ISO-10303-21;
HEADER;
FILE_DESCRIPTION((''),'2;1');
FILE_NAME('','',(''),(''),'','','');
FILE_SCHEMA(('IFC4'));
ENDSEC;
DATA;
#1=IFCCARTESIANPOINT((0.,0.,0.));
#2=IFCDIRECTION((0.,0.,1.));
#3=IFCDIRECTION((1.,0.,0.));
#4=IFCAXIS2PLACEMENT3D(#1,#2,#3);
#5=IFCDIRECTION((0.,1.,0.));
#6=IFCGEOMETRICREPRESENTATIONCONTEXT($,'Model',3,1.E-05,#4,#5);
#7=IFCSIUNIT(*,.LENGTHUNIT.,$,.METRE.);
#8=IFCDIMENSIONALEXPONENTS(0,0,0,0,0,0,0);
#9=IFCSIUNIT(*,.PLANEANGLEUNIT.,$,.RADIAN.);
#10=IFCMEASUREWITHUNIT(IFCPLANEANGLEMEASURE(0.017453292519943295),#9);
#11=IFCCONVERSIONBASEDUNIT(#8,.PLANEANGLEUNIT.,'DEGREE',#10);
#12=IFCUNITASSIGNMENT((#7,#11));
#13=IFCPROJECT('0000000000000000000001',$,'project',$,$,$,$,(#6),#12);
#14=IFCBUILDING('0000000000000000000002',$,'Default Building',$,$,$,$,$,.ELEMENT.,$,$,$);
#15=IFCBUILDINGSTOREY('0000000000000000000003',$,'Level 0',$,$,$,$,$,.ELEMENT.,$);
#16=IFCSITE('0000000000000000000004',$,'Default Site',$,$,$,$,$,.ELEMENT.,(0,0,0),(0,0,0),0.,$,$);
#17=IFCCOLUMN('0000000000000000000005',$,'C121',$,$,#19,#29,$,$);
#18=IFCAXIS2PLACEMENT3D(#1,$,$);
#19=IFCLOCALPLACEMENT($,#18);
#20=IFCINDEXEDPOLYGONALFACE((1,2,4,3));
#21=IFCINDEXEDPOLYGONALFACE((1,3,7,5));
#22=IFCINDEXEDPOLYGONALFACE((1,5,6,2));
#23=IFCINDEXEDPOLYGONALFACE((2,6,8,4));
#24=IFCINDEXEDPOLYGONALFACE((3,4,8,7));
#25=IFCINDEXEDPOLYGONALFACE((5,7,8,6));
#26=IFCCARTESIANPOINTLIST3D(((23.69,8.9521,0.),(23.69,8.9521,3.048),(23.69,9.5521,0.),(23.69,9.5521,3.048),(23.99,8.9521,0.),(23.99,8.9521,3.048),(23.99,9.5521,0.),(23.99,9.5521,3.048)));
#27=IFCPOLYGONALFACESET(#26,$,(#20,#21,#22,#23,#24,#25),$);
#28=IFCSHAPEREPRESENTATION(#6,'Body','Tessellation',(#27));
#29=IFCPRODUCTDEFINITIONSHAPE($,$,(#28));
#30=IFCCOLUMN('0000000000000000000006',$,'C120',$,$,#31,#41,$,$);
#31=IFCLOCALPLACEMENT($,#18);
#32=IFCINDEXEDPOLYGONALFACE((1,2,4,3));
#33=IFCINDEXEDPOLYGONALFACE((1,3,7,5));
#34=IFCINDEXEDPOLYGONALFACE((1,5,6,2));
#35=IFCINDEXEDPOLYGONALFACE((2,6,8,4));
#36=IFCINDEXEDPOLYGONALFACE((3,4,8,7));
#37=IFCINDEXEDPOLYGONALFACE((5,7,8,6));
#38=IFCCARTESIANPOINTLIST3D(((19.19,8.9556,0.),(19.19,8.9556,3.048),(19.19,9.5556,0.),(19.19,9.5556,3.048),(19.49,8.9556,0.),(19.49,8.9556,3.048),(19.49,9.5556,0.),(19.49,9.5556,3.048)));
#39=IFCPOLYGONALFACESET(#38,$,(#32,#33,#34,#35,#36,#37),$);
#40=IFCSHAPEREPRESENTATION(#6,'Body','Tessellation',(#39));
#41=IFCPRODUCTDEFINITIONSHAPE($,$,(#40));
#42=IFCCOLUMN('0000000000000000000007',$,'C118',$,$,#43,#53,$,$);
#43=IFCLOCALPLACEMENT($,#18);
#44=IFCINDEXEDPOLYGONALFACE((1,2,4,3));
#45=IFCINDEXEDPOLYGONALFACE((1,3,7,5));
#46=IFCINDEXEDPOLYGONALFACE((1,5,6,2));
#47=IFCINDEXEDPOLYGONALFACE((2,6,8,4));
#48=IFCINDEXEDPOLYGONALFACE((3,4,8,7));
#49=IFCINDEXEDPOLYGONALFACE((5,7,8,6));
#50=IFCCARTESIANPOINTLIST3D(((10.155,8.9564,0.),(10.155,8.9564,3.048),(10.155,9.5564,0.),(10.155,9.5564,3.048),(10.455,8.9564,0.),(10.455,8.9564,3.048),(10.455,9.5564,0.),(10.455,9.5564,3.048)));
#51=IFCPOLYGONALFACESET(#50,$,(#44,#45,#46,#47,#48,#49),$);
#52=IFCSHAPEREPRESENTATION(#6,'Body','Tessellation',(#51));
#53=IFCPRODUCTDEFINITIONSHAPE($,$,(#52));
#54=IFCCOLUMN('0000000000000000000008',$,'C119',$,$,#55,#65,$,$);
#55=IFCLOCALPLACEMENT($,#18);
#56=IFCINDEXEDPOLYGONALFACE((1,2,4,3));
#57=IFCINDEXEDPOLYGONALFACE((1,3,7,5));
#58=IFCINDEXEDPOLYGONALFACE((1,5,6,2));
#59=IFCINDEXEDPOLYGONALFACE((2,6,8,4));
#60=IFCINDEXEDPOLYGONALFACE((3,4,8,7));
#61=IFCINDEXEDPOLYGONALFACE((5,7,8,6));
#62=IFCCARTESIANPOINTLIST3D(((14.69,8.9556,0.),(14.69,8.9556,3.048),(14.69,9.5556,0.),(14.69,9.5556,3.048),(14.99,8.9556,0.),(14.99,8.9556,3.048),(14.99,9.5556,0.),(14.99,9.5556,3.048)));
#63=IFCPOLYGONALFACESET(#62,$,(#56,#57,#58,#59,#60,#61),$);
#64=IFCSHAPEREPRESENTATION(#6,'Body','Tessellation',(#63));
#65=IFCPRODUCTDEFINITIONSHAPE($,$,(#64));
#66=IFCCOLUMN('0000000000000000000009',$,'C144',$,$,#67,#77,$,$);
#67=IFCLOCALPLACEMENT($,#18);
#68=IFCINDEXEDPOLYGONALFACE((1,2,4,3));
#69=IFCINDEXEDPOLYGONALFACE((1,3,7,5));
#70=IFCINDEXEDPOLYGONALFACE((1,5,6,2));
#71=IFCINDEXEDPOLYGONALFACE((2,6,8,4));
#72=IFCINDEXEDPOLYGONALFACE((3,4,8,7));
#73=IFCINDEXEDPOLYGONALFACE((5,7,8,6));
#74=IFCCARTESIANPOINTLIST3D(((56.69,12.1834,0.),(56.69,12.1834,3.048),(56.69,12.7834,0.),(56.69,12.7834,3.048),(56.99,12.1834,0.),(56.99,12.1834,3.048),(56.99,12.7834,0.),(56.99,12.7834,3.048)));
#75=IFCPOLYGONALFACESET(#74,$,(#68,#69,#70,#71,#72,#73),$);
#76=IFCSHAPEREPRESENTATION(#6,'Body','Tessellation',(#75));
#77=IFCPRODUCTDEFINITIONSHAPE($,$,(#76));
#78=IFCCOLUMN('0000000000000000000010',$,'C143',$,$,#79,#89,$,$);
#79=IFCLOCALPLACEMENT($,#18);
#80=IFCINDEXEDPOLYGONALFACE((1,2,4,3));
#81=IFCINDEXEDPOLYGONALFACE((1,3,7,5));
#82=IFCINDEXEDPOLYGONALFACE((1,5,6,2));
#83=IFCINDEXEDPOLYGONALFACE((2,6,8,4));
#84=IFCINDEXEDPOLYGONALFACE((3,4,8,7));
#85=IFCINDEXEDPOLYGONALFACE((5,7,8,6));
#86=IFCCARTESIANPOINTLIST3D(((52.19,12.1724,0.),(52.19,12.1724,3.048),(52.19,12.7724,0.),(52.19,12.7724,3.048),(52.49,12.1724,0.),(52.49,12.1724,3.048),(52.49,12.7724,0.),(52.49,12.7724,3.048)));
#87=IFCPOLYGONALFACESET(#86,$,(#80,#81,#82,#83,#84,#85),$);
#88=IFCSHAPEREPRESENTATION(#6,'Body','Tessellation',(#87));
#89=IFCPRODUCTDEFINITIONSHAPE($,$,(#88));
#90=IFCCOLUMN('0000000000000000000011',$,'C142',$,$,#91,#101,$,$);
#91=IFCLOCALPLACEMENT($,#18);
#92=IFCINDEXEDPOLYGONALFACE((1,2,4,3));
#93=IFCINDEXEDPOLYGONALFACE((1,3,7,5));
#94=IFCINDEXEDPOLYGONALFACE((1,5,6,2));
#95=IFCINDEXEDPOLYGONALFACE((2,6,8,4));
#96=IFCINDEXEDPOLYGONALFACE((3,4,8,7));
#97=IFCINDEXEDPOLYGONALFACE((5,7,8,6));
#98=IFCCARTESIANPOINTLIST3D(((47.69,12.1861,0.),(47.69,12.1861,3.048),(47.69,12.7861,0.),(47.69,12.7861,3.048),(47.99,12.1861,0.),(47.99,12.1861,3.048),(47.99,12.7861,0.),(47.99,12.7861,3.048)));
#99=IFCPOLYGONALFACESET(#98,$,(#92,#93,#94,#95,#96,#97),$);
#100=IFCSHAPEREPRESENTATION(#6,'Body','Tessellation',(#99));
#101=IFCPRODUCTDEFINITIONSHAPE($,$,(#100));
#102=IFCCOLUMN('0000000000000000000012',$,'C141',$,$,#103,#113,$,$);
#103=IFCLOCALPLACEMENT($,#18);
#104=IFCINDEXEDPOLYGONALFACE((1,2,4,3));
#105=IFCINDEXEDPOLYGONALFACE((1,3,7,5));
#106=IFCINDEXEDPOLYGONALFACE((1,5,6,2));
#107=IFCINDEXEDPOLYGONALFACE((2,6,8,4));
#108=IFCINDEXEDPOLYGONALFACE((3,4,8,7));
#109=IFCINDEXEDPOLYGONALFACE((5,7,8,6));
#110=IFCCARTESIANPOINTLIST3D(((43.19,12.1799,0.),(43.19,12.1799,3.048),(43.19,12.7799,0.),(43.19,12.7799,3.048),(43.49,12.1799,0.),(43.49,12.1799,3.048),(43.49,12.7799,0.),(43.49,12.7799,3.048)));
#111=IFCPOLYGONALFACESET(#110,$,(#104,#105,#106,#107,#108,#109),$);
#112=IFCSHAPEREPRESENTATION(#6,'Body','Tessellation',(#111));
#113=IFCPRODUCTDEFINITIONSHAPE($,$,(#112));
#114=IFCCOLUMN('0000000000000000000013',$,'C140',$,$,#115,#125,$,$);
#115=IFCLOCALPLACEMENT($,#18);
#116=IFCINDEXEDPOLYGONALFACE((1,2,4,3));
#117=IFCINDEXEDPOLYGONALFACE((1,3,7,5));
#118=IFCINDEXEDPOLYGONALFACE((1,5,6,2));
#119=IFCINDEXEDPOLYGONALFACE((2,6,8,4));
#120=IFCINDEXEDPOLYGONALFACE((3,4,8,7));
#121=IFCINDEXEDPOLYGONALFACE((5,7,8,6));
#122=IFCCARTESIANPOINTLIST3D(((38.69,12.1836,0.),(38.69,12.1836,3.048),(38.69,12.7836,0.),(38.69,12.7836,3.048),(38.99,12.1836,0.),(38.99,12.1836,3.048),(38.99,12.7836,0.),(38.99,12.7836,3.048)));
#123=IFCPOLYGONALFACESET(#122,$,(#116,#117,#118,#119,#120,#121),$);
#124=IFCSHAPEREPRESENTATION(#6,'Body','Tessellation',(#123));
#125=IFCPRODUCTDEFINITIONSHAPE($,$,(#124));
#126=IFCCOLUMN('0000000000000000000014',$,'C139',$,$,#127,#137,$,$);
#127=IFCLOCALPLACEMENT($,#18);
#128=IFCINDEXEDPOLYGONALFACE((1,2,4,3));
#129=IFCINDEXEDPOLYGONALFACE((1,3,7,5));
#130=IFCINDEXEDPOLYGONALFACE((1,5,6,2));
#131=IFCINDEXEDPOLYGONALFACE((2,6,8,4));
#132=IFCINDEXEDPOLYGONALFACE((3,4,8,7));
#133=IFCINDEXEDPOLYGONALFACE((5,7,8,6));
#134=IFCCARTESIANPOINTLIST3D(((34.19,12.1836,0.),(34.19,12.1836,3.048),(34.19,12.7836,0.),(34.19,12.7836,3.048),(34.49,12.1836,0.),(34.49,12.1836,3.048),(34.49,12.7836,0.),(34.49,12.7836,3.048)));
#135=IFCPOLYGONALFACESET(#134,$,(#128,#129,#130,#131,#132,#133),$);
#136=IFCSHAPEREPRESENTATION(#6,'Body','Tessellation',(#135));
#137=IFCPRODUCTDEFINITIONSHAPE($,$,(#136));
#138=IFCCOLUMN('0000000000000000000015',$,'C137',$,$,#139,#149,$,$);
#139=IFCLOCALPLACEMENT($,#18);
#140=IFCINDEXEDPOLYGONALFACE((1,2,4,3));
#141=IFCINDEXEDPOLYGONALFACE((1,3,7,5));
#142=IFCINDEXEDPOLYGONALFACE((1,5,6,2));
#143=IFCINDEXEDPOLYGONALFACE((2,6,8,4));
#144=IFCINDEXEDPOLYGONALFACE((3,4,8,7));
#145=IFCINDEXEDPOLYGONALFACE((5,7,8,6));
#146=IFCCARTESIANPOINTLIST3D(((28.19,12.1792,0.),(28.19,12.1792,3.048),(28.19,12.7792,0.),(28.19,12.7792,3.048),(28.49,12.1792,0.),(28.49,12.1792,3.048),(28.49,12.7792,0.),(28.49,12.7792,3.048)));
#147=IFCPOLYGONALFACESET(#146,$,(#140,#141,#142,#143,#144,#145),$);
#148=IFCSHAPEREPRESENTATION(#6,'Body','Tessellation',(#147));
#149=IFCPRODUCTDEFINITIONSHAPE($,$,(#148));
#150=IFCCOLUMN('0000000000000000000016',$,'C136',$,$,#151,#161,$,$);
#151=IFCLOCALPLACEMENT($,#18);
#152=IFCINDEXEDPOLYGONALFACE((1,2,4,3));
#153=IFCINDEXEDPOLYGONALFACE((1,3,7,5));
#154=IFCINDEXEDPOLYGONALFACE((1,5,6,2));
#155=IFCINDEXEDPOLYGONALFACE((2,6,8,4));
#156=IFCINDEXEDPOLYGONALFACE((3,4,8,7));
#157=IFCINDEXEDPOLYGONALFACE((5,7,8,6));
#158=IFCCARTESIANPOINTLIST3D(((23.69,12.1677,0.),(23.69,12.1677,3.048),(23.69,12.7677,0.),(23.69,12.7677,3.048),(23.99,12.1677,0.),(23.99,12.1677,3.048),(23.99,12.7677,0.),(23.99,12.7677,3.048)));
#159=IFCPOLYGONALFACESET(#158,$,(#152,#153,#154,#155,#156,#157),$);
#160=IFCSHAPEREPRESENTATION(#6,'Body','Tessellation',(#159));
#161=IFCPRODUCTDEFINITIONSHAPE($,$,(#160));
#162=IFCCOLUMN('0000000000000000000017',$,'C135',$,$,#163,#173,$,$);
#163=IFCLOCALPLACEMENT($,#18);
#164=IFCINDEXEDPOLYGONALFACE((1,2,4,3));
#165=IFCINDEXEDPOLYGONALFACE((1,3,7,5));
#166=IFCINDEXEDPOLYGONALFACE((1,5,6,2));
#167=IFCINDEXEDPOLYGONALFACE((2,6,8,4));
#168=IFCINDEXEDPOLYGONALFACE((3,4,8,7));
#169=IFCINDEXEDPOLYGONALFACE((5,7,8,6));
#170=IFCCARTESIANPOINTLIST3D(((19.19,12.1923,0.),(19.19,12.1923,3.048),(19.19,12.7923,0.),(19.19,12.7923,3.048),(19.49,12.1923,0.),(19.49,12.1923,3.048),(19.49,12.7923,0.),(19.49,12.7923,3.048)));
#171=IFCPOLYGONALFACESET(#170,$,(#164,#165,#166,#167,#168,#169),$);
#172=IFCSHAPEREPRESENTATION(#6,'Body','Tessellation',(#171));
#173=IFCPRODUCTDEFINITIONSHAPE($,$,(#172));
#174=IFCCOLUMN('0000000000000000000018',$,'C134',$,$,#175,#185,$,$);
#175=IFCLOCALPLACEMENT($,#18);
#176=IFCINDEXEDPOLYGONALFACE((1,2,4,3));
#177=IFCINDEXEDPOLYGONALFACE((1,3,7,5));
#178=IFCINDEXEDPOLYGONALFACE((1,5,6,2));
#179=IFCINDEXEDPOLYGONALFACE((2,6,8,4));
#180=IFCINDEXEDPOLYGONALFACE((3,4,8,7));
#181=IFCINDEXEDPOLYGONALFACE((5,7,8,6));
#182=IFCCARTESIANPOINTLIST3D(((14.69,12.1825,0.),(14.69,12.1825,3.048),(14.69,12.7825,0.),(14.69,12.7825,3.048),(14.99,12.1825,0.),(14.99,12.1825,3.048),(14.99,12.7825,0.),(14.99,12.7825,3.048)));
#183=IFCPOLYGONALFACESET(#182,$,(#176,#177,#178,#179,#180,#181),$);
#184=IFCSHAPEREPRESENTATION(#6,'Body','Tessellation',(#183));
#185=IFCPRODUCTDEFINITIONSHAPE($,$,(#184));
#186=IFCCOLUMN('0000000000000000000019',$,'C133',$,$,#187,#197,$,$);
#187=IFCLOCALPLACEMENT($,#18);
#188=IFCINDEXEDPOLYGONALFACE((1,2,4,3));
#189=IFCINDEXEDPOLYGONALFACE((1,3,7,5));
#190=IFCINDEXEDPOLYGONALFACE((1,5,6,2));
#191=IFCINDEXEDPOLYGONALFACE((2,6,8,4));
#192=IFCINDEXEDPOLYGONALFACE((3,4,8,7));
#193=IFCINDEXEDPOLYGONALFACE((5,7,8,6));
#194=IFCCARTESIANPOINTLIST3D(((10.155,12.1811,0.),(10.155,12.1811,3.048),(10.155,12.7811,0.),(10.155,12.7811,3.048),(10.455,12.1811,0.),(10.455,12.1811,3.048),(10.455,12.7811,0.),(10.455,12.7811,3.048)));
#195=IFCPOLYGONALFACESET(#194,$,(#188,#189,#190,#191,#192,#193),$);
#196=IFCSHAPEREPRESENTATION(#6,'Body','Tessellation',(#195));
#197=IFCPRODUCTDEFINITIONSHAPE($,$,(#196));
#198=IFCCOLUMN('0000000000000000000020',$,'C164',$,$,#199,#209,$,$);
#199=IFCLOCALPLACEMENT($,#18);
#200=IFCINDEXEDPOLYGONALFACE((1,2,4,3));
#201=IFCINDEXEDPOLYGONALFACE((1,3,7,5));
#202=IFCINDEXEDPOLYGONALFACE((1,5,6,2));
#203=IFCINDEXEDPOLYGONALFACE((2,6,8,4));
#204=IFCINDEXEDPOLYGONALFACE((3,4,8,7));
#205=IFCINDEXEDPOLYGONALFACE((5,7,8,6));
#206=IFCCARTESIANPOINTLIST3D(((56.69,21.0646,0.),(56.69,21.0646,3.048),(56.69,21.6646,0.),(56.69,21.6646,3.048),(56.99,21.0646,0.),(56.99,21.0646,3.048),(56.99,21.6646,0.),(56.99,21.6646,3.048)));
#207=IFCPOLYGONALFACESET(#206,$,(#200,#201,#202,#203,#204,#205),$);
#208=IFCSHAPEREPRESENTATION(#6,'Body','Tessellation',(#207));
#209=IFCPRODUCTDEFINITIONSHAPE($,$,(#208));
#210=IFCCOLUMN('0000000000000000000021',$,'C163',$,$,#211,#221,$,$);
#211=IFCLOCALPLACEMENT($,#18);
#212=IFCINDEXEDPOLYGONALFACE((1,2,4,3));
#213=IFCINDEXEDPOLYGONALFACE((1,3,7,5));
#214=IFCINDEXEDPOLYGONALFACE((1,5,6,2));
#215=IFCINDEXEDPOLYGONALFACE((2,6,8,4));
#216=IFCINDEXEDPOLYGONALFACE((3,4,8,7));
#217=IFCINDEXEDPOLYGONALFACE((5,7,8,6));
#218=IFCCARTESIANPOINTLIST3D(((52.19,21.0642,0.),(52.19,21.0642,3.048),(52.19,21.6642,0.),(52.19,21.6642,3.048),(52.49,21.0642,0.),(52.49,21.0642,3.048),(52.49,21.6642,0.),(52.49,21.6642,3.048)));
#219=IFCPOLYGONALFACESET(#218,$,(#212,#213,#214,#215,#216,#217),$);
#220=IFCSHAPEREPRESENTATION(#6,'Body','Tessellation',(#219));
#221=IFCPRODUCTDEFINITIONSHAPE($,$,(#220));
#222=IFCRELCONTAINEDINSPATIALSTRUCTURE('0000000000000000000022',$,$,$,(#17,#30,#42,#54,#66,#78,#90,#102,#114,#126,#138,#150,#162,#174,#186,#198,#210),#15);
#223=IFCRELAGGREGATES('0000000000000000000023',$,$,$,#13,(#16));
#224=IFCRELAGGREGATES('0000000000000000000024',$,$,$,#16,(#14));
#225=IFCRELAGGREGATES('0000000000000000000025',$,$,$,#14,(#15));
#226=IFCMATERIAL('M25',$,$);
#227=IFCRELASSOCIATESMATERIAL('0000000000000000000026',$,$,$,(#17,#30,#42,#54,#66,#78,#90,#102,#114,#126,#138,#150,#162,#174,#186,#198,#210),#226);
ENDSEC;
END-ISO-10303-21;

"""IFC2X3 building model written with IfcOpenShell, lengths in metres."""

from ifc_helpers import new_model, entity, si_unit, converted_unit, direction, frame, frame_2d, origin_with_axes, place, context, project, spatial, rectangle, extrude, material, element, save


model = new_model("IFC2X3")

# Units and contexts
model_context = context("Model", 3, precision=1e-05, world=origin_with_axes(), true_north=direction((0.0, 1.0, 0.0)))
ifc_project = project(units=[si_unit("LENGTHUNIT", "METRE"), converted_unit("PLANEANGLEUNIT", "DEGREE", entity("IfcPlaneAngleMeasure", 0.017453292519943295), si_unit("PLANEANGLEUNIT", "RADIAN"), dimensions=[0, 0, 0, 0, 0, 0, 0])], contexts=[model_context])

# Site, building, storey
site = spatial("IfcSite", under=ifc_project, Name="Default Site", CompositionType="ELEMENT", RefLatitude=(0, 0, 0), RefLongitude=(0, 0, 0), RefElevation=0.0)
building = spatial("IfcBuilding", under=site, Name="Default Building", CompositionType="ELEMENT")
storey = spatial("IfcBuildingStorey", under=building, Name="Level 0", CompositionType="ELEMENT")

# Columns
ifc_material = material(Name="M25")
placement = place(None, origin_with_axes())
element("IfcColumn", 1, at=placement, inside=storey, material=ifc_material, Name="C121", context=model_context, shape_type="SweptSolid", body=[
    extrude(rectangle(XDim=0.3, YDim=0.6, at=frame_2d((0.0, 0.0), x_axis=(1.0, 0.0, 0.0))), frame((23.84, 9.2521, 0.0), z_axis=(0.0, 0.0, 1.0), x_axis=(1.0, 0.0, 0.0)), (0.0, 0.0, 1.0), 3.048),
])
element("IfcColumn", 2, at=placement, inside=storey, material=ifc_material, Name="C120", context=model_context, shape_type="SweptSolid", body=[
    extrude(rectangle(XDim=0.3, YDim=0.6, at=frame_2d((0.0, 0.0), x_axis=(1.0, 0.0, 0.0))), frame((19.34, 9.2556, 0.0), z_axis=(0.0, 0.0, 1.0), x_axis=(1.0, 0.0, 0.0)), (0.0, 0.0, 1.0), 3.048),
])
element("IfcColumn", 3, at=placement, inside=storey, material=ifc_material, Name="C118", context=model_context, shape_type="SweptSolid", body=[
    extrude(rectangle(XDim=0.3, YDim=0.6, at=frame_2d((0.0, 0.0), x_axis=(1.0, 0.0, 0.0))), frame((10.305, 9.2564, 0.0), z_axis=(0.0, 0.0, 1.0), x_axis=(1.0, 0.0, 0.0)), (0.0, 0.0, 1.0), 3.048),
])
element("IfcColumn", 4, at=placement, inside=storey, material=ifc_material, Name="C119", context=model_context, shape_type="SweptSolid", body=[
    extrude(rectangle(XDim=0.3, YDim=0.6, at=frame_2d((0.0, 0.0), x_axis=(1.0, 0.0, 0.0))), frame((14.84, 9.2556, 0.0), z_axis=(0.0, 0.0, 1.0), x_axis=(1.0, 0.0, 0.0)), (0.0, 0.0, 1.0), 3.048),
])
element("IfcColumn", 5, at=placement, inside=storey, material=ifc_material, Name="C144", context=model_context, shape_type="SweptSolid", body=[
    extrude(rectangle(XDim=0.3, YDim=0.6, at=frame_2d((0.0, 0.0), x_axis=(1.0, 0.0, 0.0))), frame((56.84, 12.4834, 0.0), z_axis=(0.0, 0.0, 1.0), x_axis=(1.0, 0.0, 0.0)), (0.0, 0.0, 1.0), 3.048),
])
element("IfcColumn", 6, at=placement, inside=storey, material=ifc_material, Name="C143", context=model_context, shape_type="SweptSolid", body=[
    extrude(rectangle(XDim=0.3, YDim=0.6, at=frame_2d((0.0, 0.0), x_axis=(1.0, 0.0, 0.0))), frame((52.34, 12.4724, 0.0), z_axis=(0.0, 0.0, 1.0), x_axis=(1.0, 0.0, 0.0)), (0.0, 0.0, 1.0), 3.048),
])
element("IfcColumn", 7, at=placement, inside=storey, material=ifc_material, Name="C142", context=model_context, shape_type="SweptSolid", body=[
    extrude(rectangle(XDim=0.3, YDim=0.6, at=frame_2d((0.0, 0.0), x_axis=(1.0, 0.0, 0.0))), frame((47.84, 12.4861, 0.0), z_axis=(0.0, 0.0, 1.0), x_axis=(1.0, 0.0, 0.0)), (0.0, 0.0, 1.0), 3.048),
])
element("IfcColumn", 8, at=placement, inside=storey, material=ifc_material, Name="C141", context=model_context, shape_type="SweptSolid", body=[
    extrude(rectangle(XDim=0.3, YDim=0.6, at=frame_2d((0.0, 0.0), x_axis=(1.0, 0.0, 0.0))), frame((43.34, 12.4799, 0.0), z_axis=(0.0, 0.0, 1.0), x_axis=(1.0, 0.0, 0.0)), (0.0, 0.0, 1.0), 3.048),
])
element("IfcColumn", 9, at=placement, inside=storey, material=ifc_material, Name="C140", context=model_context, shape_type="SweptSolid", body=[
    extrude(rectangle(XDim=0.3, YDim=0.6, at=frame_2d((0.0, 0.0), x_axis=(1.0, 0.0, 0.0))), frame((38.84, 12.4836, 0.0), z_axis=(0.0, 0.0, 1.0), x_axis=(1.0, 0.0, 0.0)), (0.0, 0.0, 1.0), 3.048),
])
element("IfcColumn", 10, at=placement, inside=storey, material=ifc_material, Name="C139", context=model_context, shape_type="SweptSolid", body=[
    extrude(rectangle(XDim=0.3, YDim=0.6, at=frame_2d((0.0, 0.0), x_axis=(1.0, 0.0, 0.0))), frame((34.34, 12.4836, 0.0), z_axis=(0.0, 0.0, 1.0), x_axis=(1.0, 0.0, 0.0)), (0.0, 0.0, 1.0), 3.048),
])
element("IfcColumn", 11, at=placement, inside=storey, material=ifc_material, Name="C137", context=model_context, shape_type="SweptSolid", body=[
    extrude(rectangle(XDim=0.3, YDim=0.6, at=frame_2d((0.0, 0.0), x_axis=(1.0, 0.0, 0.0))), frame((28.34, 12.4792, 0.0), z_axis=(0.0, 0.0, 1.0), x_axis=(1.0, 0.0, 0.0)), (0.0, 0.0, 1.0), 3.048),
])
element("IfcColumn", 12, at=placement, inside=storey, material=ifc_material, Name="C136", context=model_context, shape_type="SweptSolid", body=[
    extrude(rectangle(XDim=0.3, YDim=0.6, at=frame_2d((0.0, 0.0), x_axis=(1.0, 0.0, 0.0))), frame((23.84, 12.4677, 0.0), z_axis=(0.0, 0.0, 1.0), x_axis=(1.0, 0.0, 0.0)), (0.0, 0.0, 1.0), 3.048),
])
element("IfcColumn", 13, at=placement, inside=storey, material=ifc_material, Name="C135", context=model_context, shape_type="SweptSolid", body=[
    extrude(rectangle(XDim=0.3, YDim=0.6, at=frame_2d((0.0, 0.0), x_axis=(1.0, 0.0, 0.0))), frame((19.34, 12.4923, 0.0), z_axis=(0.0, 0.0, 1.0), x_axis=(1.0, 0.0, 0.0)), (0.0, 0.0, 1.0), 3.048),
])
element("IfcColumn", 14, at=placement, inside=storey, material=ifc_material, Name="C134", context=model_context, shape_type="SweptSolid", body=[
    extrude(rectangle(XDim=0.3, YDim=0.6, at=frame_2d((0.0, 0.0), x_axis=(1.0, 0.0, 0.0))), frame((14.84, 12.4825, 0.0), z_axis=(0.0, 0.0, 1.0), x_axis=(1.0, 0.0, 0.0)), (0.0, 0.0, 1.0), 3.048),
])
element("IfcColumn", 15, at=placement, inside=storey, material=ifc_material, Name="C133", context=model_context, shape_type="SweptSolid", body=[
    extrude(rectangle(XDim=0.3, YDim=0.6, at=frame_2d((0.0, 0.0), x_axis=(1.0, 0.0, 0.0))), frame((10.305, 12.4811, 0.0), z_axis=(0.0, 0.0, 1.0), x_axis=(1.0, 0.0, 0.0)), (0.0, 0.0, 1.0), 3.048),
])
element("IfcColumn", 16, at=placement, inside=storey, material=ifc_material, Name="C164", context=model_context, shape_type="SweptSolid", body=[
    extrude(rectangle(XDim=0.3, YDim=0.6, at=frame_2d((0.0, 0.0), x_axis=(1.0, 0.0, 0.0))), frame((56.84, 21.3646, 0.0), z_axis=(0.0, 0.0, 1.0), x_axis=(1.0, 0.0, 0.0)), (0.0, 0.0, 1.0), 3.048),
])
element("IfcColumn", 17, at=placement, inside=storey, material=ifc_material, Name="C163", context=model_context, shape_type="SweptSolid", body=[
    extrude(rectangle(XDim=0.3, YDim=0.6, at=frame_2d((0.0, 0.0), x_axis=(1.0, 0.0, 0.0))), frame((52.34, 21.3642, 0.0), z_axis=(0.0, 0.0, 1.0), x_axis=(1.0, 0.0, 0.0)), (0.0, 0.0, 1.0), 3.048),
])

save(model, "model.ifc")
